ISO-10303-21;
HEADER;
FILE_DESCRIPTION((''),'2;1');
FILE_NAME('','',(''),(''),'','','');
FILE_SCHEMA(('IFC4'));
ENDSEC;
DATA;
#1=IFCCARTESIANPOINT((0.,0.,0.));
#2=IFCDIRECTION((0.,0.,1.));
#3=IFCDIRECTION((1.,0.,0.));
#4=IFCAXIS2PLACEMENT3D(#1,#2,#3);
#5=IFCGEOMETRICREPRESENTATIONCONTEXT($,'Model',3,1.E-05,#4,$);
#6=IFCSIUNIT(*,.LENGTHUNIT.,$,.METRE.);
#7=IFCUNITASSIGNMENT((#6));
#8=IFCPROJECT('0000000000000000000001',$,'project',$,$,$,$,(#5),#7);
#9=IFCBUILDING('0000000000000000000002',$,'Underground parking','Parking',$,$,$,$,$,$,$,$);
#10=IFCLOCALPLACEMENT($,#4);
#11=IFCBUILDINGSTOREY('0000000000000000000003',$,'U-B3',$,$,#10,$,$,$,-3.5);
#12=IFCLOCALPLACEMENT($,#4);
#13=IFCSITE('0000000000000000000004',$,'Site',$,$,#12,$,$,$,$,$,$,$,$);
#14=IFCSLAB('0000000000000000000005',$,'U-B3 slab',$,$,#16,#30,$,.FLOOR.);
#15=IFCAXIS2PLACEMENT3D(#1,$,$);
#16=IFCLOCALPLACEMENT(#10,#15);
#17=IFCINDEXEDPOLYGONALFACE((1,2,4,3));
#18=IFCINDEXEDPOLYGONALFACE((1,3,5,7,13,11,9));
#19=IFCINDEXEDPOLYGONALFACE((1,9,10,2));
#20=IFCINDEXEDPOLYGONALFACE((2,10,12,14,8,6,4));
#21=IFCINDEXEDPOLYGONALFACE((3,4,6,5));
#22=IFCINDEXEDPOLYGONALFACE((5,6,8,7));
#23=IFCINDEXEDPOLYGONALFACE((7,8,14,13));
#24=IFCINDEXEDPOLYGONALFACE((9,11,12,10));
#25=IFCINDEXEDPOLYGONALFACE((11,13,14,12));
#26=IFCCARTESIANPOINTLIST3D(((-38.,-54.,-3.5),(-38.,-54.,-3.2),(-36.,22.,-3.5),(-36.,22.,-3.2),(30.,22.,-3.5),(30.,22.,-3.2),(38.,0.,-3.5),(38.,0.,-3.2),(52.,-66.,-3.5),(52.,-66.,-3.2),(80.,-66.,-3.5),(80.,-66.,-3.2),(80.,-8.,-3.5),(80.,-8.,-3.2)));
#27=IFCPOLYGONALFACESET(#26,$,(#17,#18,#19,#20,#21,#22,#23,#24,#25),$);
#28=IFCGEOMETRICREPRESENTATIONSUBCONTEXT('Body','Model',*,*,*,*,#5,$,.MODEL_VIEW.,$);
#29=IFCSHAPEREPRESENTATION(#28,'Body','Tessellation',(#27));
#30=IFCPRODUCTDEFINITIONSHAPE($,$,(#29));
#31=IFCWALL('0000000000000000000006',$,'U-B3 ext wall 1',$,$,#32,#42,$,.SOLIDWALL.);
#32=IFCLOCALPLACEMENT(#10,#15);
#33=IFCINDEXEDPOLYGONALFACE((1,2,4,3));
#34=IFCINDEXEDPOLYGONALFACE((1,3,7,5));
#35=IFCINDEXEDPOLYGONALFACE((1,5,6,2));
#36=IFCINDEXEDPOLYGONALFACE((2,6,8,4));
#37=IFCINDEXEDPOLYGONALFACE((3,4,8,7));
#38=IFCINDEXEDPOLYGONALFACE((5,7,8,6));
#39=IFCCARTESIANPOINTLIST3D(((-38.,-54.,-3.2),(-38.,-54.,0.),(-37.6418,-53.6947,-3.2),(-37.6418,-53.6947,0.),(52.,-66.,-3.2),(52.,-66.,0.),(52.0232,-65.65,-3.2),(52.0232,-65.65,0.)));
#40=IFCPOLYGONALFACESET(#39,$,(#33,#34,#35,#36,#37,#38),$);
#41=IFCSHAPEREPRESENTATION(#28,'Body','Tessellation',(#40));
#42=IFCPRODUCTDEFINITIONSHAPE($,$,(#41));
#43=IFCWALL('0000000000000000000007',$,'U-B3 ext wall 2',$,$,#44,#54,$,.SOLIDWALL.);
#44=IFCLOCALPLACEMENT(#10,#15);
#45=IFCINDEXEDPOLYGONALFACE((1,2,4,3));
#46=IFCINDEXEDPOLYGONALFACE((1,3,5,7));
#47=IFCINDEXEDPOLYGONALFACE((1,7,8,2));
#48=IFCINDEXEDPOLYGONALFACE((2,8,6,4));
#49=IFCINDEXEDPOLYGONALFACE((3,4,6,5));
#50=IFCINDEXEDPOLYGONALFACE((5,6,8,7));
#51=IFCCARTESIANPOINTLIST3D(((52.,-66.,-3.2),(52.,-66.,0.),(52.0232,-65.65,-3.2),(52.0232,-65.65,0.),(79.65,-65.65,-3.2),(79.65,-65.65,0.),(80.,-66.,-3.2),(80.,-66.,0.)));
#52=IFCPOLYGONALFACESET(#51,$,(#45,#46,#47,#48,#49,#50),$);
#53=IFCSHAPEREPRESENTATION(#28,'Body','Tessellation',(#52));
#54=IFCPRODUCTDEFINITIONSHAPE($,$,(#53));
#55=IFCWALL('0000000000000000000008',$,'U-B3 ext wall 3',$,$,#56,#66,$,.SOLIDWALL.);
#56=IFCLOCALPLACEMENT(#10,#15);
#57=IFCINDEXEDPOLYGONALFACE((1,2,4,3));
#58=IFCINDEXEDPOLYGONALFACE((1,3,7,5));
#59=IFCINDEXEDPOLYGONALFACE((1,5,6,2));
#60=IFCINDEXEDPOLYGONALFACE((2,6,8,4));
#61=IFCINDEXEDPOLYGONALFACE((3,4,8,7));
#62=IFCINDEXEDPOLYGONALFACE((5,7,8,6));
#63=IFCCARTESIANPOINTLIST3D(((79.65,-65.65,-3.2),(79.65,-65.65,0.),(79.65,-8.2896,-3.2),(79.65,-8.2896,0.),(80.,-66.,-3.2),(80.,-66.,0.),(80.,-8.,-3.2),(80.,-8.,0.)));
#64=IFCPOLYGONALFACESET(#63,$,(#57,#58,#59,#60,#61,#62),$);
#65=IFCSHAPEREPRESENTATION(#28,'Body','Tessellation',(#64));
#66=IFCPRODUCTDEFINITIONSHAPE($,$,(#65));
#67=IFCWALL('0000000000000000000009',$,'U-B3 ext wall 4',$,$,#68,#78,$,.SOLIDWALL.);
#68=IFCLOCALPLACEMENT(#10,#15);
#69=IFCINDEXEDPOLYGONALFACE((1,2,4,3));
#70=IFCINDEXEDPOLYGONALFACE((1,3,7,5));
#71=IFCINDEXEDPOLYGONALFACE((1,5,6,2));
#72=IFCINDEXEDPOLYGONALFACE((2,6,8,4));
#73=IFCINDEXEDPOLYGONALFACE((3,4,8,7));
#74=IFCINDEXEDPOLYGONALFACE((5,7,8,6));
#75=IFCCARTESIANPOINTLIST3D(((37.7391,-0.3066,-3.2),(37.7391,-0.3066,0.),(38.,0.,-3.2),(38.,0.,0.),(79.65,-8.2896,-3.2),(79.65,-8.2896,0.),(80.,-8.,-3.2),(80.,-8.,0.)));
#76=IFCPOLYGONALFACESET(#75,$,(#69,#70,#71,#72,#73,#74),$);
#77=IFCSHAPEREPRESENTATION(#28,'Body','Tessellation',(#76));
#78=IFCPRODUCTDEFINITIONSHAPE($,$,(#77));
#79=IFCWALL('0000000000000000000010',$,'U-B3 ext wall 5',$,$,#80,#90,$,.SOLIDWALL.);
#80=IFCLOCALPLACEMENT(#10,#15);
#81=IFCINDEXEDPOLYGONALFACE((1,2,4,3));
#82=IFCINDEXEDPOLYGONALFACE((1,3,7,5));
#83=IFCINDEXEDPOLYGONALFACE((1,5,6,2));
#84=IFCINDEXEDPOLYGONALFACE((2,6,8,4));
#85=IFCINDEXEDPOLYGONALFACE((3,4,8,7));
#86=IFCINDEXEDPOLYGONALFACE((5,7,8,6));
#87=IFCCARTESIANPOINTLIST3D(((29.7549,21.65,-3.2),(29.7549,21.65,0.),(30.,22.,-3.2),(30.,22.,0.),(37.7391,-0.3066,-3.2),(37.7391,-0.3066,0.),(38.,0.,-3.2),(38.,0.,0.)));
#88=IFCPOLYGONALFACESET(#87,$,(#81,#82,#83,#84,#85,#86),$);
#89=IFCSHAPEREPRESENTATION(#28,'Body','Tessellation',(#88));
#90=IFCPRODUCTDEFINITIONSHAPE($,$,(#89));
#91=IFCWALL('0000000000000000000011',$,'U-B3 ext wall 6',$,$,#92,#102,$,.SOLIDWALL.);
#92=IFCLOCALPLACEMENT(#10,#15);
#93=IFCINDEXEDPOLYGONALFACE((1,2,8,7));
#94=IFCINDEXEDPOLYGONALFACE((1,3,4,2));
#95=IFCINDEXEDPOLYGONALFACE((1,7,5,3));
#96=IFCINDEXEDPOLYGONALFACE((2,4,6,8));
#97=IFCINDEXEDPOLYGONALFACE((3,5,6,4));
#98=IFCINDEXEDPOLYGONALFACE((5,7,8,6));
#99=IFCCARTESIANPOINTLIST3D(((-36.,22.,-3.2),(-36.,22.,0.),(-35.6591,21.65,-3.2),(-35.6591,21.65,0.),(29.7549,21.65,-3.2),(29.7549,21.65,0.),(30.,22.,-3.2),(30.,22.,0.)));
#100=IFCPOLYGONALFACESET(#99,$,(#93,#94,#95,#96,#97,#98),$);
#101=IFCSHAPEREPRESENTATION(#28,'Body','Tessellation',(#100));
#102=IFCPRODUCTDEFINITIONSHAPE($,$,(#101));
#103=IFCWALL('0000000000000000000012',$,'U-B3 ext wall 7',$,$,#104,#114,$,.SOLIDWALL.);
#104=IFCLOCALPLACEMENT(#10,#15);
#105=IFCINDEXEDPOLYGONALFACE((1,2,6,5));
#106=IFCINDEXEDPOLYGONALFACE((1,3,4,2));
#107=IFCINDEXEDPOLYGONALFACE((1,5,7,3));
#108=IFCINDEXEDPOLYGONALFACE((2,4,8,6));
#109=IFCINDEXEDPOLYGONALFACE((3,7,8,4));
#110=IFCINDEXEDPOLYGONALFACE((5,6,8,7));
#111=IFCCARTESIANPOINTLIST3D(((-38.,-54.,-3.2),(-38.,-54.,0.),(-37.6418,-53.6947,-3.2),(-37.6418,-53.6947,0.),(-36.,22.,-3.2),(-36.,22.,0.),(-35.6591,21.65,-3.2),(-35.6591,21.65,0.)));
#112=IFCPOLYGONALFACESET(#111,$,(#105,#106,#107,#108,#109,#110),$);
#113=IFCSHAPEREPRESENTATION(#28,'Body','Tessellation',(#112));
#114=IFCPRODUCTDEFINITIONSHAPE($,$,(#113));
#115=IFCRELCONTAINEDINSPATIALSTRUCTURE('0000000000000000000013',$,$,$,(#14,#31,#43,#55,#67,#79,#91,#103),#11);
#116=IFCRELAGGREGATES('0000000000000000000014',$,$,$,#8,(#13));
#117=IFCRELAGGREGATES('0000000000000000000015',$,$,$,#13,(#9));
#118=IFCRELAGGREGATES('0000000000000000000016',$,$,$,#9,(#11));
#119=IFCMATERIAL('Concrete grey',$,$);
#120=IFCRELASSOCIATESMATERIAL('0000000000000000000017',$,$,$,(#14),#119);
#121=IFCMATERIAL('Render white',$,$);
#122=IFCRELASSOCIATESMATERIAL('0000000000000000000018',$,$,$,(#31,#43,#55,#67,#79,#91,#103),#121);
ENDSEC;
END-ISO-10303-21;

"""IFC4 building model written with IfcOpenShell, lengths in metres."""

from ifc_helpers import new_model, si_unit, frame, origin_with_axes, place, context, subcontext, project, spatial, polyline, outline, extrude, material, element, save


model = new_model("IFC4")

# Units and contexts
model_context = context("Model", 3, precision=1e-05, world=origin_with_axes())
body_context = subcontext(model_context, "Body", "Model", "MODEL_VIEW")
ifc_project = project(units=[si_unit("LENGTHUNIT", "METRE")], contexts=[model_context])

# Site, building, storey
site_placement = place(None, origin_with_axes())
site = spatial("IfcSite", under=ifc_project, at=site_placement, Name="Site")
building = spatial("IfcBuilding", under=site, Name="Underground parking", Description="Parking")
storey_placement = place(None, origin_with_axes())
storey = spatial("IfcBuildingStorey", under=building, at=storey_placement, Name="U-B3", Elevation=-3.5)

# Slab
ifc_material_1 = material(Name="Concrete grey")
slab_placement = place(storey_placement, origin_with_axes())
element("IfcSlab", 1, at=slab_placement, inside=storey, material=ifc_material_1, Name="U-B3 slab", PredefinedType="FLOOR", context=body_context, shape_type="SweptSolid", body=[
    extrude(outline(polyline([(-38.0, -54.0), (52.0, -66.0), (80.0, -66.0), (80.0, -8.0), (38.0, 0.0), (30.0, 22.0), (-36.0, 22.0), (-38.0, -54.0)])), frame((0.0, 0.0, -3.5), z_axis=(0.0, 0.0, 1.0), x_axis=(1.0, 0.0, 0.0)), (0.0, 0.0, 1.0), 0.3),
])

# Walls
ifc_material_2 = material(Name="Render white")
wall_1_placement = place(storey_placement, origin_with_axes())
element("IfcWall", 2, at=wall_1_placement, inside=storey, material=ifc_material_2, Name="U-B3 ext wall 1", PredefinedType="SOLIDWALL", context=body_context, shape_type="SweptSolid", body=[
    extrude(outline(polyline([(-38.0, -54.0), (52.0, -66.0), (52.0232, -65.65), (-37.6418, -53.6947), (-38.0, -54.0)])), frame((0.0, 0.0, -3.2), z_axis=(0.0, 0.0, 1.0), x_axis=(1.0, 0.0, 0.0)), (0.0, 0.0, 1.0), 3.2),
])
wall_2_placement = place(storey_placement, origin_with_axes())
element("IfcWall", 3, at=wall_2_placement, inside=storey, material=ifc_material_2, Name="U-B3 ext wall 2", PredefinedType="SOLIDWALL", context=body_context, shape_type="SweptSolid", body=[
    extrude(outline(polyline([(52.0, -66.0), (80.0, -66.0), (79.65, -65.65), (52.0232, -65.65), (52.0, -66.0)])), frame((0.0, 0.0, -3.2), z_axis=(0.0, 0.0, 1.0), x_axis=(1.0, 0.0, 0.0)), (0.0, 0.0, 1.0), 3.2),
])
wall_3_placement = place(storey_placement, origin_with_axes())
element("IfcWall", 4, at=wall_3_placement, inside=storey, material=ifc_material_2, Name="U-B3 ext wall 3", PredefinedType="SOLIDWALL", context=body_context, shape_type="SweptSolid", body=[
    extrude(outline(polyline([(80.0, -66.0), (80.0, -8.0), (79.65, -8.2896), (79.65, -65.65), (80.0, -66.0)])), frame((0.0, 0.0, -3.2), z_axis=(0.0, 0.0, 1.0), x_axis=(1.0, 0.0, 0.0)), (0.0, 0.0, 1.0), 3.2),
])
wall_4_placement = place(storey_placement, origin_with_axes())
element("IfcWall", 5, at=wall_4_placement, inside=storey, material=ifc_material_2, Name="U-B3 ext wall 4", PredefinedType="SOLIDWALL", context=body_context, shape_type="SweptSolid", body=[
    extrude(outline(polyline([(80.0, -8.0), (38.0, 0.0), (37.7391, -0.3066), (79.65, -8.2896), (80.0, -8.0)])), frame((0.0, 0.0, -3.2), z_axis=(0.0, 0.0, 1.0), x_axis=(1.0, 0.0, 0.0)), (0.0, 0.0, 1.0), 3.2),
])
wall_5_placement = place(storey_placement, origin_with_axes())
element("IfcWall", 6, at=wall_5_placement, inside=storey, material=ifc_material_2, Name="U-B3 ext wall 5", PredefinedType="SOLIDWALL", context=body_context, shape_type="SweptSolid", body=[
    extrude(outline(polyline([(38.0, 0.0), (30.0, 22.0), (29.7549, 21.65), (37.7391, -0.3066), (38.0, 0.0)])), frame((0.0, 0.0, -3.2), z_axis=(0.0, 0.0, 1.0), x_axis=(1.0, 0.0, 0.0)), (0.0, 0.0, 1.0), 3.2),
])
wall_6_placement = place(storey_placement, origin_with_axes())
element("IfcWall", 7, at=wall_6_placement, inside=storey, material=ifc_material_2, Name="U-B3 ext wall 6", PredefinedType="SOLIDWALL", context=body_context, shape_type="SweptSolid", body=[
    extrude(outline(polyline([(30.0, 22.0), (-36.0, 22.0), (-35.6591, 21.65), (29.7549, 21.65), (30.0, 22.0)])), frame((0.0, 0.0, -3.2), z_axis=(0.0, 0.0, 1.0), x_axis=(1.0, 0.0, 0.0)), (0.0, 0.0, 1.0), 3.2),
])
wall_7_placement = place(storey_placement, origin_with_axes())
element("IfcWall", 8, at=wall_7_placement, inside=storey, material=ifc_material_2, Name="U-B3 ext wall 7", PredefinedType="SOLIDWALL", context=body_context, shape_type="SweptSolid", body=[
    extrude(outline(polyline([(-36.0, 22.0), (-38.0, -54.0), (-37.6418, -53.6947), (-35.6591, 21.65), (-36.0, 22.0)])), frame((0.0, 0.0, -3.2), z_axis=(0.0, 0.0, 1.0), x_axis=(1.0, 0.0, 0.0)), (0.0, 0.0, 1.0), 3.2),
])

save(model, "model.ifc")
